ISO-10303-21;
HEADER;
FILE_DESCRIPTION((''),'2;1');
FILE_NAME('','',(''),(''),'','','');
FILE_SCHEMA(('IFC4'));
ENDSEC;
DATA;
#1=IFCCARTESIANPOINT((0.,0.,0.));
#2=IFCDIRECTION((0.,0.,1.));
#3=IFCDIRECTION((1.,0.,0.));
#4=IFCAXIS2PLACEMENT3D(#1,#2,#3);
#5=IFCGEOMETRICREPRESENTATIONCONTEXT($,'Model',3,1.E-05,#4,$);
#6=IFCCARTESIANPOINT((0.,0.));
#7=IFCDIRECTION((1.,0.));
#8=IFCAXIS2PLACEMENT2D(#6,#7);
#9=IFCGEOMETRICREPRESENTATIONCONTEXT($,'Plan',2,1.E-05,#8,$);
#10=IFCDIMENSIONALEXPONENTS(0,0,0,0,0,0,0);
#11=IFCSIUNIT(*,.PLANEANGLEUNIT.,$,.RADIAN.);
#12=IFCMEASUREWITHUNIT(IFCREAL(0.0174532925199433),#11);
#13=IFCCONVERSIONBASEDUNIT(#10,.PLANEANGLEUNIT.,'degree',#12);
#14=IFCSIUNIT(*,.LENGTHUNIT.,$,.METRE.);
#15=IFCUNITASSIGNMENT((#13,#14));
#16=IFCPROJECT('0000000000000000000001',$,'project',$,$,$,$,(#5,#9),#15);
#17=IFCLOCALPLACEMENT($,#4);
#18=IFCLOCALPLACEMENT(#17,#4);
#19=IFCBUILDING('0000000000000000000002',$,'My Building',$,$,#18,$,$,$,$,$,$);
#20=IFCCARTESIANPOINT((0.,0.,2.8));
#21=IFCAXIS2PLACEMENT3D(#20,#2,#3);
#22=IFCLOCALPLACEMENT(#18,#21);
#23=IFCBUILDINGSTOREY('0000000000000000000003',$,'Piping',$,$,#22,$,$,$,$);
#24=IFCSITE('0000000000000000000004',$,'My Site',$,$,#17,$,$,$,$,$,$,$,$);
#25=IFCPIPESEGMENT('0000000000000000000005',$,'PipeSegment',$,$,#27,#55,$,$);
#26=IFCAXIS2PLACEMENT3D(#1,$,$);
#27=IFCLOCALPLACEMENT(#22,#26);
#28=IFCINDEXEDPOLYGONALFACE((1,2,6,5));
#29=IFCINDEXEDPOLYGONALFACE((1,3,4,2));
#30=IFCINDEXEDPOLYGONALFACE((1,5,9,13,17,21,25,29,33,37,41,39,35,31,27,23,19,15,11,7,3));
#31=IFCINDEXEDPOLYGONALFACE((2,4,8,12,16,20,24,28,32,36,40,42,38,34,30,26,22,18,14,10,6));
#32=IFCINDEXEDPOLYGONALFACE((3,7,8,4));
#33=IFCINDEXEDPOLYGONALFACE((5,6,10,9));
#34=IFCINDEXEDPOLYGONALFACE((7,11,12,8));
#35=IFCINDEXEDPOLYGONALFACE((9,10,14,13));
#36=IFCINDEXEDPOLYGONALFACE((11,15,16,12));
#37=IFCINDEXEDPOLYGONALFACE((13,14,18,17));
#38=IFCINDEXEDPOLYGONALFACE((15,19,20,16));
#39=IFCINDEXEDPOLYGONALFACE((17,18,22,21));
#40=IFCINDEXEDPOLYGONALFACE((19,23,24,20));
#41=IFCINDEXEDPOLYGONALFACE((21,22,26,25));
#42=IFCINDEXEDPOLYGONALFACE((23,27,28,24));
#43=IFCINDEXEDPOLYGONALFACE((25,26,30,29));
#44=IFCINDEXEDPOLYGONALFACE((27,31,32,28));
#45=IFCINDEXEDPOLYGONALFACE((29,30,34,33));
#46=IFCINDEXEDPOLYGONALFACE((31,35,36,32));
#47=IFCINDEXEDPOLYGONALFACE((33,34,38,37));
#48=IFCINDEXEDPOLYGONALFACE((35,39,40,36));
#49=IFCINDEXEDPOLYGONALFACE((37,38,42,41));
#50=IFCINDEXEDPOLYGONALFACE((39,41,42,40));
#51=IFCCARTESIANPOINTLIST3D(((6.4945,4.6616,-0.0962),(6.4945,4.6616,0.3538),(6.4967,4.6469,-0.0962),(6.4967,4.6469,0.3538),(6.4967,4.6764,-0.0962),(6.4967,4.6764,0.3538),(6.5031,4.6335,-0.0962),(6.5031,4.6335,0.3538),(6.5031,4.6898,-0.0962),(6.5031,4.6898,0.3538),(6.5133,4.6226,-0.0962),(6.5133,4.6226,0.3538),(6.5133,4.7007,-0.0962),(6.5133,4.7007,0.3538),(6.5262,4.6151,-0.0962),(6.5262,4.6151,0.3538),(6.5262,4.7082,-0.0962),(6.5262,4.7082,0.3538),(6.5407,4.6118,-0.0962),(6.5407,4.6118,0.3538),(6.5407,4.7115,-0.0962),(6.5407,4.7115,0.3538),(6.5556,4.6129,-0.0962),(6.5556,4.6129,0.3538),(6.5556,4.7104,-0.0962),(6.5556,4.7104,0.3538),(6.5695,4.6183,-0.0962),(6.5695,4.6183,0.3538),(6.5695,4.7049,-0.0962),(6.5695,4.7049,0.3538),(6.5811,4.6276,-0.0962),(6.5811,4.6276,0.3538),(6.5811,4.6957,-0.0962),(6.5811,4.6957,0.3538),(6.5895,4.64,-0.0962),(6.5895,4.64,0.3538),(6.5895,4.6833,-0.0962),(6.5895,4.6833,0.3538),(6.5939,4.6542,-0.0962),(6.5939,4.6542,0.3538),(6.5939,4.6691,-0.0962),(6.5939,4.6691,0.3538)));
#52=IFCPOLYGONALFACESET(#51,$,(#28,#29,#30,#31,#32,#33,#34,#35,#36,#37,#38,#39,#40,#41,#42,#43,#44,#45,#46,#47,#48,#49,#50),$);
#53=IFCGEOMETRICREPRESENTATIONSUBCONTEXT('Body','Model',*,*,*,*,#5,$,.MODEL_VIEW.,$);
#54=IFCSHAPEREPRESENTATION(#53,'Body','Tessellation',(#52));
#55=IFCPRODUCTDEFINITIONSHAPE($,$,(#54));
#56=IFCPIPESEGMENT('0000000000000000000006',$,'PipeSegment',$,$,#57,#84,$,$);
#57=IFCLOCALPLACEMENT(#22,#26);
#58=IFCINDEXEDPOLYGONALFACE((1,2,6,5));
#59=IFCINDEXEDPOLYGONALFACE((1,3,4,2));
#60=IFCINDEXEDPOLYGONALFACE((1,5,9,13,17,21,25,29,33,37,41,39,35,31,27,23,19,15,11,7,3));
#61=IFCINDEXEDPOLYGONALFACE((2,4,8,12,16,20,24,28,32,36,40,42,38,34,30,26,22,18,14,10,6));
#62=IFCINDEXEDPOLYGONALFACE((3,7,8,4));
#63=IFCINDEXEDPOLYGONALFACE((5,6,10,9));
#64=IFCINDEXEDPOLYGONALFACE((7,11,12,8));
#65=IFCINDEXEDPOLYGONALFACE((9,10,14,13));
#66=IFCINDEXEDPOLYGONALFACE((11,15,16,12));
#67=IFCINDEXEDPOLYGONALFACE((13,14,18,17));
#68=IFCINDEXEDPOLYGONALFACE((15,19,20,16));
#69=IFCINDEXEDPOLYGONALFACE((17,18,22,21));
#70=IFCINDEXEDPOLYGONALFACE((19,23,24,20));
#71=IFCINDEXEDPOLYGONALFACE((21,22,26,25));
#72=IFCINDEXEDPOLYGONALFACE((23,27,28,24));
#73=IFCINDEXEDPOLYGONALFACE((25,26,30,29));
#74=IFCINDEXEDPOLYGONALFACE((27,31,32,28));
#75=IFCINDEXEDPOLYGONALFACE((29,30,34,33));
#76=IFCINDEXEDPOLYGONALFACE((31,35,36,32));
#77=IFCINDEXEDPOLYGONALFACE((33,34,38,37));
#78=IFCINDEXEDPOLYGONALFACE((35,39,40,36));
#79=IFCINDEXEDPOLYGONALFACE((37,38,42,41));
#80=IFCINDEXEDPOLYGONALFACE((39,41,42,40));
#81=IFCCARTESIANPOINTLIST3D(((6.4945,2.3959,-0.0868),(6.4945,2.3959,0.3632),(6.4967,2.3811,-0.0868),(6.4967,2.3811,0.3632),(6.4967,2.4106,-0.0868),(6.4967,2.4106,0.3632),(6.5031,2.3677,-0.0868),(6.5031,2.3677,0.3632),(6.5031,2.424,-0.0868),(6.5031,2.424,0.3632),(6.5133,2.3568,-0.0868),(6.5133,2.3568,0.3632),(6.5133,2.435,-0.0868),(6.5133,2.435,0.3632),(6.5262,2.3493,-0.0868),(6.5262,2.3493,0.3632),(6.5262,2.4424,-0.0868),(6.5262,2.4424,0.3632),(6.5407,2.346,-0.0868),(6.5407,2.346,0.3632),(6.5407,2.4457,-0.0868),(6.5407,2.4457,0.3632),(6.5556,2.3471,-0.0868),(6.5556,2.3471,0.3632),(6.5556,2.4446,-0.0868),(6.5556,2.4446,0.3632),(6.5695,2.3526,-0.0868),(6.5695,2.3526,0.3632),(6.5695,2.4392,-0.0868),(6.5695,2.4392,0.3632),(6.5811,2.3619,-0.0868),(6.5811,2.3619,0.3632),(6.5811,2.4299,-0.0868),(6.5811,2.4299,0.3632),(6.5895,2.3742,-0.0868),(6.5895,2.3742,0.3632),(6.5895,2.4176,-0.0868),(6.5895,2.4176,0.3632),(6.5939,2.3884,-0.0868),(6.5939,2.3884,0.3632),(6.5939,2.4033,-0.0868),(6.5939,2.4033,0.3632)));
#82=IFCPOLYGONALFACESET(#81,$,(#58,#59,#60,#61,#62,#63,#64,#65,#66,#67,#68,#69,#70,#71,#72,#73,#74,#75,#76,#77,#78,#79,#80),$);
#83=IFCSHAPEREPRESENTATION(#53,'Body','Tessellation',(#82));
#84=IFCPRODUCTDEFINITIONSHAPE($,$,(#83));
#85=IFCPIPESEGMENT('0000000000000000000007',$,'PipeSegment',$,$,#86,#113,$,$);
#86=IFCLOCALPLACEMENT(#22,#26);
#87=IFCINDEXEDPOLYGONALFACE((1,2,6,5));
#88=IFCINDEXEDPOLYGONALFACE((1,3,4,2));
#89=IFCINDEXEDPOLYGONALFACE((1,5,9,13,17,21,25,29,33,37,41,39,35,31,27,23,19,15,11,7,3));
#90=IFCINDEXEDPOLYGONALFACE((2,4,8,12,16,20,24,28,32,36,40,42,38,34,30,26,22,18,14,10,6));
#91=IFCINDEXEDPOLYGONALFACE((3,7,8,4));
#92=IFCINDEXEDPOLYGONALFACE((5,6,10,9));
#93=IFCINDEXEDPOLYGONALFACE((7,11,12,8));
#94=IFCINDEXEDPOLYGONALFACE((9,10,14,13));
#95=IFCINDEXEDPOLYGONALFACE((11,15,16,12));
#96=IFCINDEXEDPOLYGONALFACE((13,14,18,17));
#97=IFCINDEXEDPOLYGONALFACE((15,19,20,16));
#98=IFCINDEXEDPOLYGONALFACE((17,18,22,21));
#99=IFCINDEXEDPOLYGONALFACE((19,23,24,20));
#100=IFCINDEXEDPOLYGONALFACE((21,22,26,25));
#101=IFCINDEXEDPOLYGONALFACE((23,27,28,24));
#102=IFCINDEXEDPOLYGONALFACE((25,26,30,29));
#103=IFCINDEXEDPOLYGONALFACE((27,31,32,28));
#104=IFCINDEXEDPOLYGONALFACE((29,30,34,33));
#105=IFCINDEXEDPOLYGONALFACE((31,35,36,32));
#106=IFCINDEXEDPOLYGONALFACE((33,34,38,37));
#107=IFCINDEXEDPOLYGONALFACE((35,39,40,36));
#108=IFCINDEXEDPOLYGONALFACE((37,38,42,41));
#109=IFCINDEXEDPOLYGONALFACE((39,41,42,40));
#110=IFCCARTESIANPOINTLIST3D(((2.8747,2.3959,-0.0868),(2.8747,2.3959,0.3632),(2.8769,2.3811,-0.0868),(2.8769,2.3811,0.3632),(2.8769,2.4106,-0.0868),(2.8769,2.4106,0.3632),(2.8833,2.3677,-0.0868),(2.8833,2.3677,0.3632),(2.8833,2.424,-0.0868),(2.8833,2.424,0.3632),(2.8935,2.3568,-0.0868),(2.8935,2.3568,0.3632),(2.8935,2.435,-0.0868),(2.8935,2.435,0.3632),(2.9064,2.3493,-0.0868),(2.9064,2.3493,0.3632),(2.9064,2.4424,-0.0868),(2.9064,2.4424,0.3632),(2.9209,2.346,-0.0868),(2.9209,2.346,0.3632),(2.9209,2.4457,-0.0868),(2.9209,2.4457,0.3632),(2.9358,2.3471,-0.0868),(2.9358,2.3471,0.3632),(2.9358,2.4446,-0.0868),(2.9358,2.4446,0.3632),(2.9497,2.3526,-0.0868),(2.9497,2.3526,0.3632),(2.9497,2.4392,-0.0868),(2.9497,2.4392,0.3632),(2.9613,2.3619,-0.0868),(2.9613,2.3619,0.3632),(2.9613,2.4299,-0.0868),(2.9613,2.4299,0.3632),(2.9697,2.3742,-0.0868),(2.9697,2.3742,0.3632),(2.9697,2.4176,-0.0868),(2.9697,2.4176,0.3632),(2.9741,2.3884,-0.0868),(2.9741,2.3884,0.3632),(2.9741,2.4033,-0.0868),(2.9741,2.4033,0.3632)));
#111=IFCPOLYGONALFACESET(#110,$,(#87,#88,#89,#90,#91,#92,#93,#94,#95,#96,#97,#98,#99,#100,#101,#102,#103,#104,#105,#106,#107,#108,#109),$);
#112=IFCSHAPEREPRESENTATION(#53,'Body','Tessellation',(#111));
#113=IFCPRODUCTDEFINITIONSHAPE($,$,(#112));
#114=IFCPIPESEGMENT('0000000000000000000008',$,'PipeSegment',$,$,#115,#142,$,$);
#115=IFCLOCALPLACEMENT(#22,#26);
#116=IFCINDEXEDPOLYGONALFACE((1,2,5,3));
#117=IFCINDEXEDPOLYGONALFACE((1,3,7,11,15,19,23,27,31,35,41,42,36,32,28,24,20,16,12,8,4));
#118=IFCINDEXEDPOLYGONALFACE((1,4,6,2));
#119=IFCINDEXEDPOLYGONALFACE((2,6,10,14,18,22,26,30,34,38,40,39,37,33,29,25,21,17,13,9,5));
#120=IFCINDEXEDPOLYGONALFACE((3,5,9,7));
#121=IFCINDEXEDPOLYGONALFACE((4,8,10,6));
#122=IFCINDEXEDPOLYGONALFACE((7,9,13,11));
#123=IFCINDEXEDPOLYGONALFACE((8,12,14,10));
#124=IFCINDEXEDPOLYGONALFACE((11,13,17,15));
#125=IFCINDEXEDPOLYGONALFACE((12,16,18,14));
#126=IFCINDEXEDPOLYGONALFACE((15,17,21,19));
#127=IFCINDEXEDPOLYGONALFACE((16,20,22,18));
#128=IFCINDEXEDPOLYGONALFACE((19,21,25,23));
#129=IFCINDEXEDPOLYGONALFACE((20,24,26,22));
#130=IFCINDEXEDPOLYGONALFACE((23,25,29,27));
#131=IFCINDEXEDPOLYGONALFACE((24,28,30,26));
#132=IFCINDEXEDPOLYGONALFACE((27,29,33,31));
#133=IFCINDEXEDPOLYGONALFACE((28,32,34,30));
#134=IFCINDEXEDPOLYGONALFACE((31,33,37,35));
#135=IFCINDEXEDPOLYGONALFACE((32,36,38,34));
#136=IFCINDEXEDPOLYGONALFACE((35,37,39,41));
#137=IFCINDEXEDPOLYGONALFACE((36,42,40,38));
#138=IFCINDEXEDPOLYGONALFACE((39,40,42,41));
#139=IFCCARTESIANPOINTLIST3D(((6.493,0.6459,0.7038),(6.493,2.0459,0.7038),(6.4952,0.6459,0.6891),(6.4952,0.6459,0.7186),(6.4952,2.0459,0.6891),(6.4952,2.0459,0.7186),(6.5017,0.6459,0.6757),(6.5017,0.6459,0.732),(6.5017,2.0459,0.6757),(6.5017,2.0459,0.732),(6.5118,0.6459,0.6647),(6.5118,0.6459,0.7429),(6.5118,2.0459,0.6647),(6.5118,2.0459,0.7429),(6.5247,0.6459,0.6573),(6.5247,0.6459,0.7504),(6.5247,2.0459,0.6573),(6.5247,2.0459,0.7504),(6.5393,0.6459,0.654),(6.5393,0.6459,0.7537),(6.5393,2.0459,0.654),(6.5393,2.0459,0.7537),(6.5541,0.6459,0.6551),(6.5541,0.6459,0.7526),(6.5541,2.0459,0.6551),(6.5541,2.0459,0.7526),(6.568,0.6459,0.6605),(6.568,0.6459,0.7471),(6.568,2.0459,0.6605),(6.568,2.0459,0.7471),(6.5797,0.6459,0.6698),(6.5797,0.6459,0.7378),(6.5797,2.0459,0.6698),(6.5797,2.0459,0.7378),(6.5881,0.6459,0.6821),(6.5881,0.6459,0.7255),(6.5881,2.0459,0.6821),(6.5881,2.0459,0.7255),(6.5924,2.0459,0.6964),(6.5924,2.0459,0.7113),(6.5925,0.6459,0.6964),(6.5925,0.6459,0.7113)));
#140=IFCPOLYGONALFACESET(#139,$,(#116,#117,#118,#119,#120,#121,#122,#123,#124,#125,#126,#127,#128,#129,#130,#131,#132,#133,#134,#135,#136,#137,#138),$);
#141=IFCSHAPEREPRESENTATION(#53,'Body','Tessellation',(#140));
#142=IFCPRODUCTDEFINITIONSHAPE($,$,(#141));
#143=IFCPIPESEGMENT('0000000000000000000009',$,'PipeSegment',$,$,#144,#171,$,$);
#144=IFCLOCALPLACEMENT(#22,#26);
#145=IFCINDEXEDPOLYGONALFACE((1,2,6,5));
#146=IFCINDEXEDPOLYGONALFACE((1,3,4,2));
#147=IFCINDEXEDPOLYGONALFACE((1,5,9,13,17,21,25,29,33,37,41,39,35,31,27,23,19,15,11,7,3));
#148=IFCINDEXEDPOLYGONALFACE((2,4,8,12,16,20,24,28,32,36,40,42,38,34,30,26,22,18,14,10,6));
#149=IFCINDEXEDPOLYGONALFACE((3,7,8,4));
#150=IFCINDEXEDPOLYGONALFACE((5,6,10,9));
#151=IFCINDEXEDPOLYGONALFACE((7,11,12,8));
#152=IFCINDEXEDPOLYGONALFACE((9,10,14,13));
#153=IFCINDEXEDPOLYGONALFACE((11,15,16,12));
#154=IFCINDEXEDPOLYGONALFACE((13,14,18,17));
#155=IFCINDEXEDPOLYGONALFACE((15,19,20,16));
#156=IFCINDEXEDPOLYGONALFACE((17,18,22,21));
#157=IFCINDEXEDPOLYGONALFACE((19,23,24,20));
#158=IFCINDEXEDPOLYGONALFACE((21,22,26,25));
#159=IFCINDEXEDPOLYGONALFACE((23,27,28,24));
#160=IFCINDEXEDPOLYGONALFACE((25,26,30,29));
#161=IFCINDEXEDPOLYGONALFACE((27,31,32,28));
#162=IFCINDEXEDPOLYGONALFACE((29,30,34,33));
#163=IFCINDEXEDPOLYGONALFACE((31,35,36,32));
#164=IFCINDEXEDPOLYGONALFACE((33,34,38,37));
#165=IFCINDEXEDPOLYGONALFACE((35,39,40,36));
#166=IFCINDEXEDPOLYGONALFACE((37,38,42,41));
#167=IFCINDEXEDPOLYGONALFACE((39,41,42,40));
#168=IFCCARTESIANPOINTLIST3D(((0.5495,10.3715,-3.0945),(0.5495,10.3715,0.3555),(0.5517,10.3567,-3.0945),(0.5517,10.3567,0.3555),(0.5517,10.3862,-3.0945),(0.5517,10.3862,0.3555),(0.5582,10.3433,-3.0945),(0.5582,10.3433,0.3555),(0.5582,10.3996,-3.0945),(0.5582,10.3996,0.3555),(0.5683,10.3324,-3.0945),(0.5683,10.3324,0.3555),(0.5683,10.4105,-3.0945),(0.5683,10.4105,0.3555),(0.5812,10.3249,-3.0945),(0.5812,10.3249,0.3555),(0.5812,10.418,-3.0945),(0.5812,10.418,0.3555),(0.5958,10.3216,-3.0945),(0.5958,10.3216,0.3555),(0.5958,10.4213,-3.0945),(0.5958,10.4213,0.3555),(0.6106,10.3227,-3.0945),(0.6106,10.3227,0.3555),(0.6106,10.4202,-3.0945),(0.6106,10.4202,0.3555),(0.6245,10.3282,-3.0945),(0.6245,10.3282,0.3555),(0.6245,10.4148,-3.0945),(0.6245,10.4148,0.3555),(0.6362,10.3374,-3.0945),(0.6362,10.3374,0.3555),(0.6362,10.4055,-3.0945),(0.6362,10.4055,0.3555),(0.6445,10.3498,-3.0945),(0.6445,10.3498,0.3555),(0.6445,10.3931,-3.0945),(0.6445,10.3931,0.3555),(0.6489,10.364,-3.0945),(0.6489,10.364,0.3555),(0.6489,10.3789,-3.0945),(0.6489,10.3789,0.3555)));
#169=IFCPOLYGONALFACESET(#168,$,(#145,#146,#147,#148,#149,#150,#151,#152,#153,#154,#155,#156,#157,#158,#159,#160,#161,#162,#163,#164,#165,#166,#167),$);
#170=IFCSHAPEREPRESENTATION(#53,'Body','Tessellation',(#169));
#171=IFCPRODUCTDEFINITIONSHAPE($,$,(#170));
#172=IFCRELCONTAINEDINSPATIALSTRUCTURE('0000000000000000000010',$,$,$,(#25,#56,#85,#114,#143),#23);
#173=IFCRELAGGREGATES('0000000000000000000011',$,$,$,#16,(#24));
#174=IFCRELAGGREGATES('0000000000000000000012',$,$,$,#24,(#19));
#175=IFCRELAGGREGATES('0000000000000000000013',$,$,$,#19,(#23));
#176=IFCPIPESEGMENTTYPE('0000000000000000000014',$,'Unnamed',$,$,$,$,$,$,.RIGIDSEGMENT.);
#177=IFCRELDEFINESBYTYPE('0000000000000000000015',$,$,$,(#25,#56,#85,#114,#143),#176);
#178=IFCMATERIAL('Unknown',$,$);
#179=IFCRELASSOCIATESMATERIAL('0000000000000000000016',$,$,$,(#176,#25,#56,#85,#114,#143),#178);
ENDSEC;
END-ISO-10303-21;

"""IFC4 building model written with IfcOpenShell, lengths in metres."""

from ifc_helpers import new_model, entity, si_unit, converted_unit, frame, origin_with_axes, origin_2d_with_axis, place, context, subcontext, project, spatial, circle, extrude, material, material_profile, profile_set, profile_usage, type_object, element, save


model = new_model("IFC4")

# Units and contexts
model_context = context("Model", 3, precision=1e-05, world=origin_with_axes())
plan_context = context("Plan", 2, precision=1e-05, world=origin_2d_with_axis())
body_context = subcontext(model_context, "Body", "Model", "MODEL_VIEW")
ifc_project = project(units=[converted_unit("PLANEANGLEUNIT", "degree", entity("IfcReal", 0.0174532925199433), si_unit("PLANEANGLEUNIT", "RADIAN"), dimensions=[0, 0, 0, 0, 0, 0, 0]), si_unit("LENGTHUNIT", "METRE")], contexts=[model_context, plan_context])

# Site, building, storey
site_placement = place(None, origin_with_axes())
site = spatial("IfcSite", under=ifc_project, at=site_placement, Name="My Site")
building_placement = place(site_placement, origin_with_axes())
building = spatial("IfcBuilding", under=site, at=building_placement, Name="My Building")
storey_placement = place(building_placement, frame((0.0, 0.0, 2.8), z_axis=(0.0, 0.0, 1.0), x_axis=(1.0, 0.0, 0.0)))
storey = spatial("IfcBuildingStorey", under=building, at=storey_placement, Name="Piping")

# Shared definitions
ifc_material = material(Name="Unknown")

# Pipe segments
ifc_material_profile_1 = material_profile(ifc_material, circle(Radius=0.05))
ifc_profile_set_1 = profile_set([ifc_material_profile_1])
pipe_segment_type = type_object("IfcPipeSegmentType", Name="Unnamed", PredefinedType="RIGIDSEGMENT", material=ifc_profile_set_1)
ifc_profile_usage_1 = profile_usage(ifc_profile_set_1, cardinal=5)
pipe_segment_1_placement = place(storey_placement, frame((6.5445, 4.6616, 0.3538), z_axis=(0.0, 0.0, -1.0), x_axis=(-1.0, 0.0, 0.0)))
element("IfcPipeSegment", 1, at=pipe_segment_1_placement, inside=storey, type_object=pipe_segment_type, material=ifc_profile_usage_1, Name="PipeSegment", context=body_context, shape_type="SweptSolid", body=[
    extrude(circle(Radius=0.05), origin_with_axes(), (0.0, 0.0, 1.0), 0.45),
])
ifc_profile_usage_2 = profile_usage(ifc_profile_set_1, cardinal=5)
pipe_segment_2_placement = place(storey_placement, frame((6.5445, 2.3959, 0.3632), z_axis=(0.0, 0.0, -1.0), x_axis=(-1.0, 0.0, 0.0)))
element("IfcPipeSegment", 2, at=pipe_segment_2_placement, inside=storey, type_object=pipe_segment_type, material=ifc_profile_usage_2, Name="PipeSegment", context=body_context, shape_type="SweptSolid", body=[
    extrude(circle(Radius=0.05), origin_with_axes(), (0.0, 0.0, 1.0), 0.45),
])
ifc_profile_usage_3 = profile_usage(ifc_profile_set_1, cardinal=5)
pipe_segment_3_placement = place(storey_placement, frame((2.9247, 2.3959, 0.3632), z_axis=(0.0, 0.0, -1.0), x_axis=(-1.0, 0.0, 0.0)))
element("IfcPipeSegment", 3, at=pipe_segment_3_placement, inside=storey, type_object=pipe_segment_type, material=ifc_profile_usage_3, Name="PipeSegment", context=body_context, shape_type="SweptSolid", body=[
    extrude(circle(Radius=0.05), origin_with_axes(), (0.0, 0.0, 1.0), 0.45),
])
ifc_profile_usage_4 = profile_usage(ifc_profile_set_1, cardinal=5)
pipe_segment_4_placement = place(storey_placement, frame((6.543, 0.6459, 0.7038), z_axis=(0.0, 1.0, 0.0), x_axis=(-1.0, 0.0, 0.0)))
element("IfcPipeSegment", 4, at=pipe_segment_4_placement, inside=storey, type_object=pipe_segment_type, material=ifc_profile_usage_4, Name="PipeSegment", context=body_context, shape_type="SweptSolid", body=[
    extrude(circle(Radius=0.05), origin_with_axes(), (0.0, 0.0, 1.0), 1.4),
])
ifc_profile_usage_5 = profile_usage(ifc_profile_set_1, cardinal=5)
pipe_segment_5_placement = place(storey_placement, frame((0.5995, 10.3715, 0.3555), z_axis=(0.0, 0.0, -1.0), x_axis=(-1.0, 0.0, 0.0)))
element("IfcPipeSegment", 5, at=pipe_segment_5_placement, inside=storey, type_object=pipe_segment_type, material=ifc_profile_usage_5, Name="PipeSegment", context=body_context, shape_type="SweptSolid", body=[
    extrude(circle(Radius=0.05), origin_with_axes(), (0.0, 0.0, 1.0), 3.45),
])

save(model, "model.ifc")
